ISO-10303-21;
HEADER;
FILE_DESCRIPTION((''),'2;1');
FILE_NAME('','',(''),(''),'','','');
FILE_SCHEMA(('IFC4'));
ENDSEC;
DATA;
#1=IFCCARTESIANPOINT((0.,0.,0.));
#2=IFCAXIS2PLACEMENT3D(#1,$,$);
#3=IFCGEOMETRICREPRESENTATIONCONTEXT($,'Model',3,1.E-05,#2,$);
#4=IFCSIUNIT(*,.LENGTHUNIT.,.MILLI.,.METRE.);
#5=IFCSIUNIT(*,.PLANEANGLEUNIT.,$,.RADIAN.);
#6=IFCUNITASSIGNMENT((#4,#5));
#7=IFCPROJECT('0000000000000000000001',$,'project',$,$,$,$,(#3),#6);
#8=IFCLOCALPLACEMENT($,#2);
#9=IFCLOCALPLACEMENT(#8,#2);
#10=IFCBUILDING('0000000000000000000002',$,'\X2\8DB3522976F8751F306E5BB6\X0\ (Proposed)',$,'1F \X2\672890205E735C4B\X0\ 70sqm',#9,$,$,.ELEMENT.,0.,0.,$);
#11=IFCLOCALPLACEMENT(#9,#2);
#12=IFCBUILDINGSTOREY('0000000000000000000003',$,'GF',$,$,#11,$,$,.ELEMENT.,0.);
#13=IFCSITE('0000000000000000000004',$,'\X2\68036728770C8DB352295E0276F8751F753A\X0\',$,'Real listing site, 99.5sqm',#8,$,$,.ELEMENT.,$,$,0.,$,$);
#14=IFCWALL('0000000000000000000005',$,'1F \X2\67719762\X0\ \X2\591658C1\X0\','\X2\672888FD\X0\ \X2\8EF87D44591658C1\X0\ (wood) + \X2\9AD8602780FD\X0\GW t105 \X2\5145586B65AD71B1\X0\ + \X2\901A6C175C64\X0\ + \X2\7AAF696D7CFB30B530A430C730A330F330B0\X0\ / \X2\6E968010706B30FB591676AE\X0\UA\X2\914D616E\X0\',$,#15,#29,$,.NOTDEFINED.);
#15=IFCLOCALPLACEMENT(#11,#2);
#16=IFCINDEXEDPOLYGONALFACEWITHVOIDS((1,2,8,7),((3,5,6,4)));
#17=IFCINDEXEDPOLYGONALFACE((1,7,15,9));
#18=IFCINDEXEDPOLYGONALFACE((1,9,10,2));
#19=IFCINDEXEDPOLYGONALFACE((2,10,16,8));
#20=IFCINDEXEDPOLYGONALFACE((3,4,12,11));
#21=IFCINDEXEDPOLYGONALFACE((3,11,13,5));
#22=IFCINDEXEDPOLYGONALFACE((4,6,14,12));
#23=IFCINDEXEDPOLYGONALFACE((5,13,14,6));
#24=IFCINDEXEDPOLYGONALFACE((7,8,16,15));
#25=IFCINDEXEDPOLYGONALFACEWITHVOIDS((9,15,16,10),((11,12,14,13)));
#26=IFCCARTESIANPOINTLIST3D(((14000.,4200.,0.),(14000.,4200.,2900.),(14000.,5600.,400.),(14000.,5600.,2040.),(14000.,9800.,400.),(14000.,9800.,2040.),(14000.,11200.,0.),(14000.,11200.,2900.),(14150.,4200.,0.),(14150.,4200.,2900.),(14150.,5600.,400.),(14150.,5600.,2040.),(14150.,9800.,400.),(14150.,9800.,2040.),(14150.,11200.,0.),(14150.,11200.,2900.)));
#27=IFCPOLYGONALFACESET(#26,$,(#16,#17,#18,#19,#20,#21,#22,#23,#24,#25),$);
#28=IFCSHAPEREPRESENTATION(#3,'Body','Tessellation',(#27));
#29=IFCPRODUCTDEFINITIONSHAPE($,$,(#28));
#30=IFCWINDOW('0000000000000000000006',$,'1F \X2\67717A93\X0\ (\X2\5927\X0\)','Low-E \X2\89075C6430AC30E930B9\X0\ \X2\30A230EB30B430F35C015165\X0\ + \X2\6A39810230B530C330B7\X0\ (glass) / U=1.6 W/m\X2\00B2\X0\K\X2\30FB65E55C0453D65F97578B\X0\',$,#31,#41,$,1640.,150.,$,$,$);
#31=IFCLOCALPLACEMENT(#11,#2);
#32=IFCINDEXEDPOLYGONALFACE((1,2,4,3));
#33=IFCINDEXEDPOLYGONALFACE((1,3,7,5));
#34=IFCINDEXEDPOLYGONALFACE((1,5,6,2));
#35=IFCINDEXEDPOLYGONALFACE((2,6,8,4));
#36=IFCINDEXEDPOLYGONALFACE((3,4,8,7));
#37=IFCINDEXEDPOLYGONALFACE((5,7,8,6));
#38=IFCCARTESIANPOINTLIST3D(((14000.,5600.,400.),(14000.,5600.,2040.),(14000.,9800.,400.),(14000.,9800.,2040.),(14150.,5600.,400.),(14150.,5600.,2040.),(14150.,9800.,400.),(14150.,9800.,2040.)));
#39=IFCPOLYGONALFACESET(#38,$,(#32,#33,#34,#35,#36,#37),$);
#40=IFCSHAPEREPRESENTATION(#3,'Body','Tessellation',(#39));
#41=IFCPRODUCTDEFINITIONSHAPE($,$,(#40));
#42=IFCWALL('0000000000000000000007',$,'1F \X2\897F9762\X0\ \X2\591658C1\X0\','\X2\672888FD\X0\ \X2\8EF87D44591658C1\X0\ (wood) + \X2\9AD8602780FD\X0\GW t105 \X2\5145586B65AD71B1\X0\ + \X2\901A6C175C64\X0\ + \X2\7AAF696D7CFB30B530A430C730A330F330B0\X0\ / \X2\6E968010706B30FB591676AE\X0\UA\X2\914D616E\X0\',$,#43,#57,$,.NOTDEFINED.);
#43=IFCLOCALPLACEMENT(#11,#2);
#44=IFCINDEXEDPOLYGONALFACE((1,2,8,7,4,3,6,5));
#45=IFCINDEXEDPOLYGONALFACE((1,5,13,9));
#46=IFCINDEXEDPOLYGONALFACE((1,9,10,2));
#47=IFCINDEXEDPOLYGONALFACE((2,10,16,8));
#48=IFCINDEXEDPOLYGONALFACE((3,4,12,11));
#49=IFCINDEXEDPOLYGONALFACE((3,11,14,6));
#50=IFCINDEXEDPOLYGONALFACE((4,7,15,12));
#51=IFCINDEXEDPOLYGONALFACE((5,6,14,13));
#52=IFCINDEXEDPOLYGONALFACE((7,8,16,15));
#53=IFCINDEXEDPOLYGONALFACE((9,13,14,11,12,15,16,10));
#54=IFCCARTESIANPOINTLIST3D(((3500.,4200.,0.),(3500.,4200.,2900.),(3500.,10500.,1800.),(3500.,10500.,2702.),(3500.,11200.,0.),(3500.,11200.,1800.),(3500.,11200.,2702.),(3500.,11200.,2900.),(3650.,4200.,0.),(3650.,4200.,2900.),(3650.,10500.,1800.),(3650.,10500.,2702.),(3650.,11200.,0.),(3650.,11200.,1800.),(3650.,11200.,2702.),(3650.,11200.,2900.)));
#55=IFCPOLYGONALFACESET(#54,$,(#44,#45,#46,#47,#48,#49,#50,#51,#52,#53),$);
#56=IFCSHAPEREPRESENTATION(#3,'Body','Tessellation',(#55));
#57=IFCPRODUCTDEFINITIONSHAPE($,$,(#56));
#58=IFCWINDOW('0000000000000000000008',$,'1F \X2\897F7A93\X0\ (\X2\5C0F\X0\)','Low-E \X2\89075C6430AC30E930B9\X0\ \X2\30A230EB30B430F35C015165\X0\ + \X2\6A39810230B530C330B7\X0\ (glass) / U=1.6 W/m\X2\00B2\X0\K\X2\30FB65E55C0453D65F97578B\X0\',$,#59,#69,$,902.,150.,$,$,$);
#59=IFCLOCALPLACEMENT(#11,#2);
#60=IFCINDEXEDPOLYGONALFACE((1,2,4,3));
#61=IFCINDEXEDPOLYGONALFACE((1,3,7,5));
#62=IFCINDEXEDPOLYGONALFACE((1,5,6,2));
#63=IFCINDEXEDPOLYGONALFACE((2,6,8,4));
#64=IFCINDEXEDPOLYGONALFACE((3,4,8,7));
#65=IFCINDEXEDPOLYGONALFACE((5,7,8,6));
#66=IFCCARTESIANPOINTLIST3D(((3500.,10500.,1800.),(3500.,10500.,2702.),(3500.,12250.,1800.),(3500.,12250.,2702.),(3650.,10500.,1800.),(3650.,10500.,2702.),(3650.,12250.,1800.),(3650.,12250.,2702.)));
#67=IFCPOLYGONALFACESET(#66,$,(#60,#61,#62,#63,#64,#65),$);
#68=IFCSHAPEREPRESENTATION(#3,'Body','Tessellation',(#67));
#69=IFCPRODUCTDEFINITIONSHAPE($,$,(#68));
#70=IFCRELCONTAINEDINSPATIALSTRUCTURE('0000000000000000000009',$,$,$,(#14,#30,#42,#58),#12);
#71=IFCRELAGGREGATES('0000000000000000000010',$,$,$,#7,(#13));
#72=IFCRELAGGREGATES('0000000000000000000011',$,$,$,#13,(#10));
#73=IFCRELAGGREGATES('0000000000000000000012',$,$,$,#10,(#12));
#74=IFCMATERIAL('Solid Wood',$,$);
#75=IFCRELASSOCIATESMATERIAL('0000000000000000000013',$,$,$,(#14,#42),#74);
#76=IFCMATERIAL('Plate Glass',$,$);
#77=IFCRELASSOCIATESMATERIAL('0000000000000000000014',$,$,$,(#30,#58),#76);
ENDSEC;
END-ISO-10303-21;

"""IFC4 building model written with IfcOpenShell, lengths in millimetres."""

from ifc_helpers import new_model, si_unit, frame, frame_2d, origin, place, context, project, spatial, rectangle, extrude, material, element, fill, save


model = new_model("IFC4")

# Units and contexts
model_context = context("Model", 3, precision=1e-05, world=origin())
ifc_project = project(units=[si_unit("LENGTHUNIT", "METRE", prefix="MILLI"), si_unit("PLANEANGLEUNIT", "RADIAN")], contexts=[model_context])

# Site, building, storey
site_placement = place(None, origin())
site = spatial("IfcSite", under=ifc_project, at=site_placement, Name="栃木県足利市相生町", ObjectType="Real listing site, 99.5sqm", CompositionType="ELEMENT", RefElevation=0.0)
building_placement = place(site_placement, origin())
building = spatial("IfcBuilding", under=site, at=building_placement, Name="足利相生の家 (Proposed)", ObjectType="1F 木造平屋 70sqm", CompositionType="ELEMENT", ElevationOfRefHeight=0.0, ElevationOfTerrain=0.0)
storey_placement = place(building_placement, origin())
storey = spatial("IfcBuildingStorey", under=building, at=storey_placement, Name="GF", CompositionType="ELEMENT", Elevation=0.0)

# Shared definitions
ifc_material_1 = material(Name="Solid Wood")

# Shared definitions
ifc_material_2 = material(Name="Plate Glass")

# Walls, openings, windows
wall_1_placement = place(storey_placement, frame((7000.0, 2100.0, 0.0)))
wall_1 = element("IfcWall", 1, at=wall_1_placement, inside=storey, material=ifc_material_1, Name="1F 東面 外壁", Description="木製 軸組外壁 (wood) + 高性能GW t105 充填断熱 + 通気層 + 窯業系サイディング / 準耐火・外皮UA配慮", PredefinedType="NOTDEFINED", context=model_context, shape_type="SweptSolid", body=[
    extrude(rectangle(XDim=150.0, YDim=7000.0, at=frame_2d((75.0, 3500.0))), frame((7000.0, 2100.0, 0.0)), (0.0, 0.0, 1.0), 2900.0),
])
opening_1_placement = place(storey_placement, frame((7000.0, 2800.0, 200.0)))
opening_1 = element("IfcOpeningElement", 2, at=opening_1_placement, cuts=wall_1, PredefinedType="NOTDEFINED", context=model_context, shape_type="SweptSolid", body=[
    extrude(rectangle(XDim=150.0, YDim=4200.0, at=frame_2d((75.0, 2100.0))), frame((7000.0, 2800.0, 200.0)), (0.0, 0.0, 1.0), 1640.0),
])
window_1_placement = place(storey_placement, frame((7000.0, 2800.0, 200.0)))
window_1 = element("IfcWindow", 3, at=window_1_placement, inside=storey, material=ifc_material_2, Name="1F 東窓 (大)", Description="Low-E 複層ガラス アルゴン封入 + 樹脂サッシ (glass) / U=1.6 W/m²K・日射取得型", OverallHeight=1640.0, OverallWidth=150.0, context=model_context, shape_type="SweptSolid", body=[
    extrude(rectangle(XDim=150.0, YDim=4200.0, at=frame_2d((75.0, 2100.0))), frame((7000.0, 2800.0, 200.0)), (0.0, 0.0, 1.0), 1640.0),
])
fill(opening_1, window_1)
wall_2_placement = place(storey_placement, frame((1750.0, 2100.0, 0.0)))
wall_2 = element("IfcWall", 4, at=wall_2_placement, inside=storey, material=ifc_material_1, Name="1F 西面 外壁", Description="木製 軸組外壁 (wood) + 高性能GW t105 充填断熱 + 通気層 + 窯業系サイディング / 準耐火・外皮UA配慮", PredefinedType="NOTDEFINED", context=model_context, shape_type="SweptSolid", body=[
    extrude(rectangle(XDim=150.0, YDim=7000.0, at=frame_2d((75.0, 3500.0))), frame((1750.0, 2100.0, 0.0)), (0.0, 0.0, 1.0), 2900.0),
])
opening_2_placement = place(storey_placement, frame((1750.0, 5250.0, 900.0)))
opening_2 = element("IfcOpeningElement", 5, at=opening_2_placement, cuts=wall_2, PredefinedType="NOTDEFINED", context=model_context, shape_type="SweptSolid", body=[
    extrude(rectangle(XDim=150.0, YDim=1750.0, at=frame_2d((75.0, 875.0))), frame((1750.0, 5250.0, 900.0)), (0.0, 0.0, 1.0), 902.0),
])
window_2_placement = place(storey_placement, frame((1750.0, 5250.0, 900.0)))
window_2 = element("IfcWindow", 6, at=window_2_placement, inside=storey, material=ifc_material_2, Name="1F 西窓 (小)", Description="Low-E 複層ガラス アルゴン封入 + 樹脂サッシ (glass) / U=1.6 W/m²K・日射取得型", OverallHeight=902.0, OverallWidth=150.0, context=model_context, shape_type="SweptSolid", body=[
    extrude(rectangle(XDim=150.0, YDim=1750.0, at=frame_2d((75.0, 875.0))), frame((1750.0, 5250.0, 900.0)), (0.0, 0.0, 1.0), 902.0),
])
fill(opening_2, window_2)

save(model, "model.ifc")
